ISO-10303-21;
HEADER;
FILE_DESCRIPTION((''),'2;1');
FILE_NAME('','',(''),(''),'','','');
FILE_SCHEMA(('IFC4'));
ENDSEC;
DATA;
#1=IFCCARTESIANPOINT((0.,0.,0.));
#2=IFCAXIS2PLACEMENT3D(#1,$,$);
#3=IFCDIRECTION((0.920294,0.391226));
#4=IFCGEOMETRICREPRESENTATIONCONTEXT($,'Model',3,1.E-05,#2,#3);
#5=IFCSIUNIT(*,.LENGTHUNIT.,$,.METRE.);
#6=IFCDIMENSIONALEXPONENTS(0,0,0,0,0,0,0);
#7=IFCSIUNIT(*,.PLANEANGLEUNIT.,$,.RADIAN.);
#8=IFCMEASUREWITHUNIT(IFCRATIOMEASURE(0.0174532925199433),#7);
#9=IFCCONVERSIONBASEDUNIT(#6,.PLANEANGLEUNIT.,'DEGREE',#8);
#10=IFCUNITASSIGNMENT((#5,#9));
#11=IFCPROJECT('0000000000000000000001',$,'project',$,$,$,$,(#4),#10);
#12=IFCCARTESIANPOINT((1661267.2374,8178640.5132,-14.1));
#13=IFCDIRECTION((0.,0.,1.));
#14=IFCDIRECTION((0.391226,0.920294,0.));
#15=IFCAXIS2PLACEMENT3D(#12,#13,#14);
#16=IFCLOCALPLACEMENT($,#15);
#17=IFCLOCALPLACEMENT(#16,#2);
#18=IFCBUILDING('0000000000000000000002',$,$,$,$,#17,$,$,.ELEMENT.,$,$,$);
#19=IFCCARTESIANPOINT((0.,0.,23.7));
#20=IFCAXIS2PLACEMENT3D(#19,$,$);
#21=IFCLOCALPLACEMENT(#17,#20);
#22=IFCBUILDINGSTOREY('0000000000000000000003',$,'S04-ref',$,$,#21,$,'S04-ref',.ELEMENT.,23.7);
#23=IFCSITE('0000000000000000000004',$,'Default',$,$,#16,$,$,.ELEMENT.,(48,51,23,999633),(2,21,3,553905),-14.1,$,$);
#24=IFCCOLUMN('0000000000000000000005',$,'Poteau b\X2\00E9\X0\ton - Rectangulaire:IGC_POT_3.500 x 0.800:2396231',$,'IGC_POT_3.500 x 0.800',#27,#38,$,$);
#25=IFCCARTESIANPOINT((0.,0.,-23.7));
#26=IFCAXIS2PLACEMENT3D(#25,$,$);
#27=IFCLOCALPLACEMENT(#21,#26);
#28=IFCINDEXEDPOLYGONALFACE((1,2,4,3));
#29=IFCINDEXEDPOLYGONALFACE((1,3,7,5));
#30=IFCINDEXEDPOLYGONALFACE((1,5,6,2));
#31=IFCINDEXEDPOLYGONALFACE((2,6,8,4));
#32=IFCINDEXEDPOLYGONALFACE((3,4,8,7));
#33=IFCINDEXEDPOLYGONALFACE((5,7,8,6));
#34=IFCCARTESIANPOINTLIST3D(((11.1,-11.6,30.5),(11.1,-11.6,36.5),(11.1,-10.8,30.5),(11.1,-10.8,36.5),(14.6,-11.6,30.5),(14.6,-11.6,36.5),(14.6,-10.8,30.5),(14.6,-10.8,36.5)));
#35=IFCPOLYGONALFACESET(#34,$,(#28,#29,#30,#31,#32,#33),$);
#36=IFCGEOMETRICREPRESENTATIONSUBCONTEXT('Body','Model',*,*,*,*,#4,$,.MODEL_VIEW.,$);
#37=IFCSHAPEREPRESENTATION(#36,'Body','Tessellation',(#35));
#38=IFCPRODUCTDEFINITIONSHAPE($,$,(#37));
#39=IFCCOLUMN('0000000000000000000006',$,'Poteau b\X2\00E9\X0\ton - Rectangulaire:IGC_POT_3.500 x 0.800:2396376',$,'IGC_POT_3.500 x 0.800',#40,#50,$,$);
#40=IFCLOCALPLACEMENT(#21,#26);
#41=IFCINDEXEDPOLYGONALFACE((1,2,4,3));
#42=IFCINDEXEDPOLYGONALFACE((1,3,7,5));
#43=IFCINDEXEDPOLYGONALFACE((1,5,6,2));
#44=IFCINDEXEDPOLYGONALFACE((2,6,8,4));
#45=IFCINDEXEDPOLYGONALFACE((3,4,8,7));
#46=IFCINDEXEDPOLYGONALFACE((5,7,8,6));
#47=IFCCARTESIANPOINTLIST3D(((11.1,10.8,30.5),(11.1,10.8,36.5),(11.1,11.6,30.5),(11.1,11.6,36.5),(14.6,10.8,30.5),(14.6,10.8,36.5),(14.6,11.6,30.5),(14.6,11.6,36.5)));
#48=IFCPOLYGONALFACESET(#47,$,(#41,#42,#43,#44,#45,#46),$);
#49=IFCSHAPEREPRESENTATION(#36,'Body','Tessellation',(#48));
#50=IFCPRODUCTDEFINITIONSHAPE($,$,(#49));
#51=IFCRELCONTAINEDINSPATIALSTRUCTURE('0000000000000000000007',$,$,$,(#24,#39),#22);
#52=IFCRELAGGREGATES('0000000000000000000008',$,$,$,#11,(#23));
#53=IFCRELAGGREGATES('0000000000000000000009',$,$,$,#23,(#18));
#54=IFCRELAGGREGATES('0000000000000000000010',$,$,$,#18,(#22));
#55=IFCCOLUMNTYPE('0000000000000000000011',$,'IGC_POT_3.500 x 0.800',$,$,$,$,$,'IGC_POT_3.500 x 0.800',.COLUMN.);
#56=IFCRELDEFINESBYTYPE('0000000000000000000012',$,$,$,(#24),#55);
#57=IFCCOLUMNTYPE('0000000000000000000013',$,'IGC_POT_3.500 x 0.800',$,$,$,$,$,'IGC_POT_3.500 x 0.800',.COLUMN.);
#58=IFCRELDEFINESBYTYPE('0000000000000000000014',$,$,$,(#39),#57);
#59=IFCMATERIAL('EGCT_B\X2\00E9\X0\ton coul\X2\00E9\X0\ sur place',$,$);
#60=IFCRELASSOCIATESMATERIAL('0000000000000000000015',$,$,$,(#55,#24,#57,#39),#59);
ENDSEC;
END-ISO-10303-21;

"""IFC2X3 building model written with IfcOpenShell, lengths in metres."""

from ifc_helpers import new_model, entity, si_unit, converted_unit, direction, frame, origin, origin_2d_with_axis, place, context, subcontext, project, spatial, rectangle, extrude, source, transform, mapped, material, type_object, type_shapes, element, save


model = new_model("IFC2X3")

# Units and contexts
model_context = context("Model", 3, precision=1e-05, world=origin(), true_north=direction((0.920294, 0.391226)))
body_context = subcontext(model_context, "Body", "Model", "MODEL_VIEW")
ifc_project = project(units=[si_unit("LENGTHUNIT", "METRE"), converted_unit("PLANEANGLEUNIT", "DEGREE", entity("IfcRatioMeasure", 0.0174532925199433), si_unit("PLANEANGLEUNIT", "RADIAN"), dimensions=[0, 0, 0, 0, 0, 0, 0])], contexts=[model_context])

# Site, building, storey
site_placement = place(None, frame((1661267.2374, 8178640.5132, -14.1), z_axis=(0.0, 0.0, 1.0), x_axis=(0.391226, 0.920294, 0.0)))
site = spatial("IfcSite", under=ifc_project, at=site_placement, Name="Default", CompositionType="ELEMENT", RefLatitude=(48, 51, 23, 999633), RefLongitude=(2, 21, 3, 553905), RefElevation=-14.1)
building_placement = place(site_placement, origin())
building = spatial("IfcBuilding", under=site, at=building_placement, CompositionType="ELEMENT")
storey_placement = place(building_placement, frame((0.0, 0.0, 23.7)))
storey = spatial("IfcBuildingStorey", under=building, at=storey_placement, Name="S04-ref", LongName="S04-ref", CompositionType="ELEMENT", Elevation=23.7)

# Columns
ifc_material_1 = material(Name="EGCT_Béton coulé sur place")
column_type_1 = type_object("IfcColumnType", Name="IGC_POT_3.500 x 0.800", ElementType="IGC_POT_3.500 x 0.800", PredefinedType="COLUMN", material=ifc_material_1)
shared_shape_1 = source(origin(), body_context, "Body", "SweptSolid", [
    extrude(rectangle(XDim=0.8, YDim=3.5, at=origin_2d_with_axis()), frame((12.85, -11.2, 30.5), z_axis=(0.0, 0.0, 1.0), x_axis=(0.0, -1.0, 0.0)), (0.0, 0.0, 1.0), 6.0),
])
type_shapes(column_type_1, [shared_shape_1])
column_1_placement = place(storey_placement, frame((0.0, 0.0, -23.7)))
element("IfcColumn", 1, at=column_1_placement, inside=storey, type_object=column_type_1, material=ifc_material_1, Name="Poteau béton - Rectangulaire:IGC_POT_3.500 x 0.800:2396231", ObjectType="IGC_POT_3.500 x 0.800", context=body_context, shape_type="MappedRepresentation", body=[
    mapped(shared_shape_1, transform((0.0, 0.0, 0.0), scale=1.0)),
])
column_type_2 = type_object("IfcColumnType", Name="IGC_POT_3.500 x 0.800", ElementType="IGC_POT_3.500 x 0.800", PredefinedType="COLUMN", material=ifc_material_1)
shared_shape_2 = source(origin(), body_context, "Body", "SweptSolid", [
    extrude(rectangle(XDim=0.8, YDim=3.5, at=origin_2d_with_axis()), frame((12.85, 11.2, 30.5), z_axis=(0.0, 0.0, 1.0), x_axis=(0.0, -1.0, 0.0)), (0.0, 0.0, 1.0), 6.0),
])
type_shapes(column_type_2, [shared_shape_2])
column_2_placement = place(storey_placement, frame((0.0, 0.0, -23.7)))
element("IfcColumn", 2, at=column_2_placement, inside=storey, type_object=column_type_2, material=ifc_material_1, Name="Poteau béton - Rectangulaire:IGC_POT_3.500 x 0.800:2396376", ObjectType="IGC_POT_3.500 x 0.800", context=body_context, shape_type="MappedRepresentation", body=[
    mapped(shared_shape_2, transform((0.0, 0.0, 0.0), scale=1.0)),
])

save(model, "model.ifc")
